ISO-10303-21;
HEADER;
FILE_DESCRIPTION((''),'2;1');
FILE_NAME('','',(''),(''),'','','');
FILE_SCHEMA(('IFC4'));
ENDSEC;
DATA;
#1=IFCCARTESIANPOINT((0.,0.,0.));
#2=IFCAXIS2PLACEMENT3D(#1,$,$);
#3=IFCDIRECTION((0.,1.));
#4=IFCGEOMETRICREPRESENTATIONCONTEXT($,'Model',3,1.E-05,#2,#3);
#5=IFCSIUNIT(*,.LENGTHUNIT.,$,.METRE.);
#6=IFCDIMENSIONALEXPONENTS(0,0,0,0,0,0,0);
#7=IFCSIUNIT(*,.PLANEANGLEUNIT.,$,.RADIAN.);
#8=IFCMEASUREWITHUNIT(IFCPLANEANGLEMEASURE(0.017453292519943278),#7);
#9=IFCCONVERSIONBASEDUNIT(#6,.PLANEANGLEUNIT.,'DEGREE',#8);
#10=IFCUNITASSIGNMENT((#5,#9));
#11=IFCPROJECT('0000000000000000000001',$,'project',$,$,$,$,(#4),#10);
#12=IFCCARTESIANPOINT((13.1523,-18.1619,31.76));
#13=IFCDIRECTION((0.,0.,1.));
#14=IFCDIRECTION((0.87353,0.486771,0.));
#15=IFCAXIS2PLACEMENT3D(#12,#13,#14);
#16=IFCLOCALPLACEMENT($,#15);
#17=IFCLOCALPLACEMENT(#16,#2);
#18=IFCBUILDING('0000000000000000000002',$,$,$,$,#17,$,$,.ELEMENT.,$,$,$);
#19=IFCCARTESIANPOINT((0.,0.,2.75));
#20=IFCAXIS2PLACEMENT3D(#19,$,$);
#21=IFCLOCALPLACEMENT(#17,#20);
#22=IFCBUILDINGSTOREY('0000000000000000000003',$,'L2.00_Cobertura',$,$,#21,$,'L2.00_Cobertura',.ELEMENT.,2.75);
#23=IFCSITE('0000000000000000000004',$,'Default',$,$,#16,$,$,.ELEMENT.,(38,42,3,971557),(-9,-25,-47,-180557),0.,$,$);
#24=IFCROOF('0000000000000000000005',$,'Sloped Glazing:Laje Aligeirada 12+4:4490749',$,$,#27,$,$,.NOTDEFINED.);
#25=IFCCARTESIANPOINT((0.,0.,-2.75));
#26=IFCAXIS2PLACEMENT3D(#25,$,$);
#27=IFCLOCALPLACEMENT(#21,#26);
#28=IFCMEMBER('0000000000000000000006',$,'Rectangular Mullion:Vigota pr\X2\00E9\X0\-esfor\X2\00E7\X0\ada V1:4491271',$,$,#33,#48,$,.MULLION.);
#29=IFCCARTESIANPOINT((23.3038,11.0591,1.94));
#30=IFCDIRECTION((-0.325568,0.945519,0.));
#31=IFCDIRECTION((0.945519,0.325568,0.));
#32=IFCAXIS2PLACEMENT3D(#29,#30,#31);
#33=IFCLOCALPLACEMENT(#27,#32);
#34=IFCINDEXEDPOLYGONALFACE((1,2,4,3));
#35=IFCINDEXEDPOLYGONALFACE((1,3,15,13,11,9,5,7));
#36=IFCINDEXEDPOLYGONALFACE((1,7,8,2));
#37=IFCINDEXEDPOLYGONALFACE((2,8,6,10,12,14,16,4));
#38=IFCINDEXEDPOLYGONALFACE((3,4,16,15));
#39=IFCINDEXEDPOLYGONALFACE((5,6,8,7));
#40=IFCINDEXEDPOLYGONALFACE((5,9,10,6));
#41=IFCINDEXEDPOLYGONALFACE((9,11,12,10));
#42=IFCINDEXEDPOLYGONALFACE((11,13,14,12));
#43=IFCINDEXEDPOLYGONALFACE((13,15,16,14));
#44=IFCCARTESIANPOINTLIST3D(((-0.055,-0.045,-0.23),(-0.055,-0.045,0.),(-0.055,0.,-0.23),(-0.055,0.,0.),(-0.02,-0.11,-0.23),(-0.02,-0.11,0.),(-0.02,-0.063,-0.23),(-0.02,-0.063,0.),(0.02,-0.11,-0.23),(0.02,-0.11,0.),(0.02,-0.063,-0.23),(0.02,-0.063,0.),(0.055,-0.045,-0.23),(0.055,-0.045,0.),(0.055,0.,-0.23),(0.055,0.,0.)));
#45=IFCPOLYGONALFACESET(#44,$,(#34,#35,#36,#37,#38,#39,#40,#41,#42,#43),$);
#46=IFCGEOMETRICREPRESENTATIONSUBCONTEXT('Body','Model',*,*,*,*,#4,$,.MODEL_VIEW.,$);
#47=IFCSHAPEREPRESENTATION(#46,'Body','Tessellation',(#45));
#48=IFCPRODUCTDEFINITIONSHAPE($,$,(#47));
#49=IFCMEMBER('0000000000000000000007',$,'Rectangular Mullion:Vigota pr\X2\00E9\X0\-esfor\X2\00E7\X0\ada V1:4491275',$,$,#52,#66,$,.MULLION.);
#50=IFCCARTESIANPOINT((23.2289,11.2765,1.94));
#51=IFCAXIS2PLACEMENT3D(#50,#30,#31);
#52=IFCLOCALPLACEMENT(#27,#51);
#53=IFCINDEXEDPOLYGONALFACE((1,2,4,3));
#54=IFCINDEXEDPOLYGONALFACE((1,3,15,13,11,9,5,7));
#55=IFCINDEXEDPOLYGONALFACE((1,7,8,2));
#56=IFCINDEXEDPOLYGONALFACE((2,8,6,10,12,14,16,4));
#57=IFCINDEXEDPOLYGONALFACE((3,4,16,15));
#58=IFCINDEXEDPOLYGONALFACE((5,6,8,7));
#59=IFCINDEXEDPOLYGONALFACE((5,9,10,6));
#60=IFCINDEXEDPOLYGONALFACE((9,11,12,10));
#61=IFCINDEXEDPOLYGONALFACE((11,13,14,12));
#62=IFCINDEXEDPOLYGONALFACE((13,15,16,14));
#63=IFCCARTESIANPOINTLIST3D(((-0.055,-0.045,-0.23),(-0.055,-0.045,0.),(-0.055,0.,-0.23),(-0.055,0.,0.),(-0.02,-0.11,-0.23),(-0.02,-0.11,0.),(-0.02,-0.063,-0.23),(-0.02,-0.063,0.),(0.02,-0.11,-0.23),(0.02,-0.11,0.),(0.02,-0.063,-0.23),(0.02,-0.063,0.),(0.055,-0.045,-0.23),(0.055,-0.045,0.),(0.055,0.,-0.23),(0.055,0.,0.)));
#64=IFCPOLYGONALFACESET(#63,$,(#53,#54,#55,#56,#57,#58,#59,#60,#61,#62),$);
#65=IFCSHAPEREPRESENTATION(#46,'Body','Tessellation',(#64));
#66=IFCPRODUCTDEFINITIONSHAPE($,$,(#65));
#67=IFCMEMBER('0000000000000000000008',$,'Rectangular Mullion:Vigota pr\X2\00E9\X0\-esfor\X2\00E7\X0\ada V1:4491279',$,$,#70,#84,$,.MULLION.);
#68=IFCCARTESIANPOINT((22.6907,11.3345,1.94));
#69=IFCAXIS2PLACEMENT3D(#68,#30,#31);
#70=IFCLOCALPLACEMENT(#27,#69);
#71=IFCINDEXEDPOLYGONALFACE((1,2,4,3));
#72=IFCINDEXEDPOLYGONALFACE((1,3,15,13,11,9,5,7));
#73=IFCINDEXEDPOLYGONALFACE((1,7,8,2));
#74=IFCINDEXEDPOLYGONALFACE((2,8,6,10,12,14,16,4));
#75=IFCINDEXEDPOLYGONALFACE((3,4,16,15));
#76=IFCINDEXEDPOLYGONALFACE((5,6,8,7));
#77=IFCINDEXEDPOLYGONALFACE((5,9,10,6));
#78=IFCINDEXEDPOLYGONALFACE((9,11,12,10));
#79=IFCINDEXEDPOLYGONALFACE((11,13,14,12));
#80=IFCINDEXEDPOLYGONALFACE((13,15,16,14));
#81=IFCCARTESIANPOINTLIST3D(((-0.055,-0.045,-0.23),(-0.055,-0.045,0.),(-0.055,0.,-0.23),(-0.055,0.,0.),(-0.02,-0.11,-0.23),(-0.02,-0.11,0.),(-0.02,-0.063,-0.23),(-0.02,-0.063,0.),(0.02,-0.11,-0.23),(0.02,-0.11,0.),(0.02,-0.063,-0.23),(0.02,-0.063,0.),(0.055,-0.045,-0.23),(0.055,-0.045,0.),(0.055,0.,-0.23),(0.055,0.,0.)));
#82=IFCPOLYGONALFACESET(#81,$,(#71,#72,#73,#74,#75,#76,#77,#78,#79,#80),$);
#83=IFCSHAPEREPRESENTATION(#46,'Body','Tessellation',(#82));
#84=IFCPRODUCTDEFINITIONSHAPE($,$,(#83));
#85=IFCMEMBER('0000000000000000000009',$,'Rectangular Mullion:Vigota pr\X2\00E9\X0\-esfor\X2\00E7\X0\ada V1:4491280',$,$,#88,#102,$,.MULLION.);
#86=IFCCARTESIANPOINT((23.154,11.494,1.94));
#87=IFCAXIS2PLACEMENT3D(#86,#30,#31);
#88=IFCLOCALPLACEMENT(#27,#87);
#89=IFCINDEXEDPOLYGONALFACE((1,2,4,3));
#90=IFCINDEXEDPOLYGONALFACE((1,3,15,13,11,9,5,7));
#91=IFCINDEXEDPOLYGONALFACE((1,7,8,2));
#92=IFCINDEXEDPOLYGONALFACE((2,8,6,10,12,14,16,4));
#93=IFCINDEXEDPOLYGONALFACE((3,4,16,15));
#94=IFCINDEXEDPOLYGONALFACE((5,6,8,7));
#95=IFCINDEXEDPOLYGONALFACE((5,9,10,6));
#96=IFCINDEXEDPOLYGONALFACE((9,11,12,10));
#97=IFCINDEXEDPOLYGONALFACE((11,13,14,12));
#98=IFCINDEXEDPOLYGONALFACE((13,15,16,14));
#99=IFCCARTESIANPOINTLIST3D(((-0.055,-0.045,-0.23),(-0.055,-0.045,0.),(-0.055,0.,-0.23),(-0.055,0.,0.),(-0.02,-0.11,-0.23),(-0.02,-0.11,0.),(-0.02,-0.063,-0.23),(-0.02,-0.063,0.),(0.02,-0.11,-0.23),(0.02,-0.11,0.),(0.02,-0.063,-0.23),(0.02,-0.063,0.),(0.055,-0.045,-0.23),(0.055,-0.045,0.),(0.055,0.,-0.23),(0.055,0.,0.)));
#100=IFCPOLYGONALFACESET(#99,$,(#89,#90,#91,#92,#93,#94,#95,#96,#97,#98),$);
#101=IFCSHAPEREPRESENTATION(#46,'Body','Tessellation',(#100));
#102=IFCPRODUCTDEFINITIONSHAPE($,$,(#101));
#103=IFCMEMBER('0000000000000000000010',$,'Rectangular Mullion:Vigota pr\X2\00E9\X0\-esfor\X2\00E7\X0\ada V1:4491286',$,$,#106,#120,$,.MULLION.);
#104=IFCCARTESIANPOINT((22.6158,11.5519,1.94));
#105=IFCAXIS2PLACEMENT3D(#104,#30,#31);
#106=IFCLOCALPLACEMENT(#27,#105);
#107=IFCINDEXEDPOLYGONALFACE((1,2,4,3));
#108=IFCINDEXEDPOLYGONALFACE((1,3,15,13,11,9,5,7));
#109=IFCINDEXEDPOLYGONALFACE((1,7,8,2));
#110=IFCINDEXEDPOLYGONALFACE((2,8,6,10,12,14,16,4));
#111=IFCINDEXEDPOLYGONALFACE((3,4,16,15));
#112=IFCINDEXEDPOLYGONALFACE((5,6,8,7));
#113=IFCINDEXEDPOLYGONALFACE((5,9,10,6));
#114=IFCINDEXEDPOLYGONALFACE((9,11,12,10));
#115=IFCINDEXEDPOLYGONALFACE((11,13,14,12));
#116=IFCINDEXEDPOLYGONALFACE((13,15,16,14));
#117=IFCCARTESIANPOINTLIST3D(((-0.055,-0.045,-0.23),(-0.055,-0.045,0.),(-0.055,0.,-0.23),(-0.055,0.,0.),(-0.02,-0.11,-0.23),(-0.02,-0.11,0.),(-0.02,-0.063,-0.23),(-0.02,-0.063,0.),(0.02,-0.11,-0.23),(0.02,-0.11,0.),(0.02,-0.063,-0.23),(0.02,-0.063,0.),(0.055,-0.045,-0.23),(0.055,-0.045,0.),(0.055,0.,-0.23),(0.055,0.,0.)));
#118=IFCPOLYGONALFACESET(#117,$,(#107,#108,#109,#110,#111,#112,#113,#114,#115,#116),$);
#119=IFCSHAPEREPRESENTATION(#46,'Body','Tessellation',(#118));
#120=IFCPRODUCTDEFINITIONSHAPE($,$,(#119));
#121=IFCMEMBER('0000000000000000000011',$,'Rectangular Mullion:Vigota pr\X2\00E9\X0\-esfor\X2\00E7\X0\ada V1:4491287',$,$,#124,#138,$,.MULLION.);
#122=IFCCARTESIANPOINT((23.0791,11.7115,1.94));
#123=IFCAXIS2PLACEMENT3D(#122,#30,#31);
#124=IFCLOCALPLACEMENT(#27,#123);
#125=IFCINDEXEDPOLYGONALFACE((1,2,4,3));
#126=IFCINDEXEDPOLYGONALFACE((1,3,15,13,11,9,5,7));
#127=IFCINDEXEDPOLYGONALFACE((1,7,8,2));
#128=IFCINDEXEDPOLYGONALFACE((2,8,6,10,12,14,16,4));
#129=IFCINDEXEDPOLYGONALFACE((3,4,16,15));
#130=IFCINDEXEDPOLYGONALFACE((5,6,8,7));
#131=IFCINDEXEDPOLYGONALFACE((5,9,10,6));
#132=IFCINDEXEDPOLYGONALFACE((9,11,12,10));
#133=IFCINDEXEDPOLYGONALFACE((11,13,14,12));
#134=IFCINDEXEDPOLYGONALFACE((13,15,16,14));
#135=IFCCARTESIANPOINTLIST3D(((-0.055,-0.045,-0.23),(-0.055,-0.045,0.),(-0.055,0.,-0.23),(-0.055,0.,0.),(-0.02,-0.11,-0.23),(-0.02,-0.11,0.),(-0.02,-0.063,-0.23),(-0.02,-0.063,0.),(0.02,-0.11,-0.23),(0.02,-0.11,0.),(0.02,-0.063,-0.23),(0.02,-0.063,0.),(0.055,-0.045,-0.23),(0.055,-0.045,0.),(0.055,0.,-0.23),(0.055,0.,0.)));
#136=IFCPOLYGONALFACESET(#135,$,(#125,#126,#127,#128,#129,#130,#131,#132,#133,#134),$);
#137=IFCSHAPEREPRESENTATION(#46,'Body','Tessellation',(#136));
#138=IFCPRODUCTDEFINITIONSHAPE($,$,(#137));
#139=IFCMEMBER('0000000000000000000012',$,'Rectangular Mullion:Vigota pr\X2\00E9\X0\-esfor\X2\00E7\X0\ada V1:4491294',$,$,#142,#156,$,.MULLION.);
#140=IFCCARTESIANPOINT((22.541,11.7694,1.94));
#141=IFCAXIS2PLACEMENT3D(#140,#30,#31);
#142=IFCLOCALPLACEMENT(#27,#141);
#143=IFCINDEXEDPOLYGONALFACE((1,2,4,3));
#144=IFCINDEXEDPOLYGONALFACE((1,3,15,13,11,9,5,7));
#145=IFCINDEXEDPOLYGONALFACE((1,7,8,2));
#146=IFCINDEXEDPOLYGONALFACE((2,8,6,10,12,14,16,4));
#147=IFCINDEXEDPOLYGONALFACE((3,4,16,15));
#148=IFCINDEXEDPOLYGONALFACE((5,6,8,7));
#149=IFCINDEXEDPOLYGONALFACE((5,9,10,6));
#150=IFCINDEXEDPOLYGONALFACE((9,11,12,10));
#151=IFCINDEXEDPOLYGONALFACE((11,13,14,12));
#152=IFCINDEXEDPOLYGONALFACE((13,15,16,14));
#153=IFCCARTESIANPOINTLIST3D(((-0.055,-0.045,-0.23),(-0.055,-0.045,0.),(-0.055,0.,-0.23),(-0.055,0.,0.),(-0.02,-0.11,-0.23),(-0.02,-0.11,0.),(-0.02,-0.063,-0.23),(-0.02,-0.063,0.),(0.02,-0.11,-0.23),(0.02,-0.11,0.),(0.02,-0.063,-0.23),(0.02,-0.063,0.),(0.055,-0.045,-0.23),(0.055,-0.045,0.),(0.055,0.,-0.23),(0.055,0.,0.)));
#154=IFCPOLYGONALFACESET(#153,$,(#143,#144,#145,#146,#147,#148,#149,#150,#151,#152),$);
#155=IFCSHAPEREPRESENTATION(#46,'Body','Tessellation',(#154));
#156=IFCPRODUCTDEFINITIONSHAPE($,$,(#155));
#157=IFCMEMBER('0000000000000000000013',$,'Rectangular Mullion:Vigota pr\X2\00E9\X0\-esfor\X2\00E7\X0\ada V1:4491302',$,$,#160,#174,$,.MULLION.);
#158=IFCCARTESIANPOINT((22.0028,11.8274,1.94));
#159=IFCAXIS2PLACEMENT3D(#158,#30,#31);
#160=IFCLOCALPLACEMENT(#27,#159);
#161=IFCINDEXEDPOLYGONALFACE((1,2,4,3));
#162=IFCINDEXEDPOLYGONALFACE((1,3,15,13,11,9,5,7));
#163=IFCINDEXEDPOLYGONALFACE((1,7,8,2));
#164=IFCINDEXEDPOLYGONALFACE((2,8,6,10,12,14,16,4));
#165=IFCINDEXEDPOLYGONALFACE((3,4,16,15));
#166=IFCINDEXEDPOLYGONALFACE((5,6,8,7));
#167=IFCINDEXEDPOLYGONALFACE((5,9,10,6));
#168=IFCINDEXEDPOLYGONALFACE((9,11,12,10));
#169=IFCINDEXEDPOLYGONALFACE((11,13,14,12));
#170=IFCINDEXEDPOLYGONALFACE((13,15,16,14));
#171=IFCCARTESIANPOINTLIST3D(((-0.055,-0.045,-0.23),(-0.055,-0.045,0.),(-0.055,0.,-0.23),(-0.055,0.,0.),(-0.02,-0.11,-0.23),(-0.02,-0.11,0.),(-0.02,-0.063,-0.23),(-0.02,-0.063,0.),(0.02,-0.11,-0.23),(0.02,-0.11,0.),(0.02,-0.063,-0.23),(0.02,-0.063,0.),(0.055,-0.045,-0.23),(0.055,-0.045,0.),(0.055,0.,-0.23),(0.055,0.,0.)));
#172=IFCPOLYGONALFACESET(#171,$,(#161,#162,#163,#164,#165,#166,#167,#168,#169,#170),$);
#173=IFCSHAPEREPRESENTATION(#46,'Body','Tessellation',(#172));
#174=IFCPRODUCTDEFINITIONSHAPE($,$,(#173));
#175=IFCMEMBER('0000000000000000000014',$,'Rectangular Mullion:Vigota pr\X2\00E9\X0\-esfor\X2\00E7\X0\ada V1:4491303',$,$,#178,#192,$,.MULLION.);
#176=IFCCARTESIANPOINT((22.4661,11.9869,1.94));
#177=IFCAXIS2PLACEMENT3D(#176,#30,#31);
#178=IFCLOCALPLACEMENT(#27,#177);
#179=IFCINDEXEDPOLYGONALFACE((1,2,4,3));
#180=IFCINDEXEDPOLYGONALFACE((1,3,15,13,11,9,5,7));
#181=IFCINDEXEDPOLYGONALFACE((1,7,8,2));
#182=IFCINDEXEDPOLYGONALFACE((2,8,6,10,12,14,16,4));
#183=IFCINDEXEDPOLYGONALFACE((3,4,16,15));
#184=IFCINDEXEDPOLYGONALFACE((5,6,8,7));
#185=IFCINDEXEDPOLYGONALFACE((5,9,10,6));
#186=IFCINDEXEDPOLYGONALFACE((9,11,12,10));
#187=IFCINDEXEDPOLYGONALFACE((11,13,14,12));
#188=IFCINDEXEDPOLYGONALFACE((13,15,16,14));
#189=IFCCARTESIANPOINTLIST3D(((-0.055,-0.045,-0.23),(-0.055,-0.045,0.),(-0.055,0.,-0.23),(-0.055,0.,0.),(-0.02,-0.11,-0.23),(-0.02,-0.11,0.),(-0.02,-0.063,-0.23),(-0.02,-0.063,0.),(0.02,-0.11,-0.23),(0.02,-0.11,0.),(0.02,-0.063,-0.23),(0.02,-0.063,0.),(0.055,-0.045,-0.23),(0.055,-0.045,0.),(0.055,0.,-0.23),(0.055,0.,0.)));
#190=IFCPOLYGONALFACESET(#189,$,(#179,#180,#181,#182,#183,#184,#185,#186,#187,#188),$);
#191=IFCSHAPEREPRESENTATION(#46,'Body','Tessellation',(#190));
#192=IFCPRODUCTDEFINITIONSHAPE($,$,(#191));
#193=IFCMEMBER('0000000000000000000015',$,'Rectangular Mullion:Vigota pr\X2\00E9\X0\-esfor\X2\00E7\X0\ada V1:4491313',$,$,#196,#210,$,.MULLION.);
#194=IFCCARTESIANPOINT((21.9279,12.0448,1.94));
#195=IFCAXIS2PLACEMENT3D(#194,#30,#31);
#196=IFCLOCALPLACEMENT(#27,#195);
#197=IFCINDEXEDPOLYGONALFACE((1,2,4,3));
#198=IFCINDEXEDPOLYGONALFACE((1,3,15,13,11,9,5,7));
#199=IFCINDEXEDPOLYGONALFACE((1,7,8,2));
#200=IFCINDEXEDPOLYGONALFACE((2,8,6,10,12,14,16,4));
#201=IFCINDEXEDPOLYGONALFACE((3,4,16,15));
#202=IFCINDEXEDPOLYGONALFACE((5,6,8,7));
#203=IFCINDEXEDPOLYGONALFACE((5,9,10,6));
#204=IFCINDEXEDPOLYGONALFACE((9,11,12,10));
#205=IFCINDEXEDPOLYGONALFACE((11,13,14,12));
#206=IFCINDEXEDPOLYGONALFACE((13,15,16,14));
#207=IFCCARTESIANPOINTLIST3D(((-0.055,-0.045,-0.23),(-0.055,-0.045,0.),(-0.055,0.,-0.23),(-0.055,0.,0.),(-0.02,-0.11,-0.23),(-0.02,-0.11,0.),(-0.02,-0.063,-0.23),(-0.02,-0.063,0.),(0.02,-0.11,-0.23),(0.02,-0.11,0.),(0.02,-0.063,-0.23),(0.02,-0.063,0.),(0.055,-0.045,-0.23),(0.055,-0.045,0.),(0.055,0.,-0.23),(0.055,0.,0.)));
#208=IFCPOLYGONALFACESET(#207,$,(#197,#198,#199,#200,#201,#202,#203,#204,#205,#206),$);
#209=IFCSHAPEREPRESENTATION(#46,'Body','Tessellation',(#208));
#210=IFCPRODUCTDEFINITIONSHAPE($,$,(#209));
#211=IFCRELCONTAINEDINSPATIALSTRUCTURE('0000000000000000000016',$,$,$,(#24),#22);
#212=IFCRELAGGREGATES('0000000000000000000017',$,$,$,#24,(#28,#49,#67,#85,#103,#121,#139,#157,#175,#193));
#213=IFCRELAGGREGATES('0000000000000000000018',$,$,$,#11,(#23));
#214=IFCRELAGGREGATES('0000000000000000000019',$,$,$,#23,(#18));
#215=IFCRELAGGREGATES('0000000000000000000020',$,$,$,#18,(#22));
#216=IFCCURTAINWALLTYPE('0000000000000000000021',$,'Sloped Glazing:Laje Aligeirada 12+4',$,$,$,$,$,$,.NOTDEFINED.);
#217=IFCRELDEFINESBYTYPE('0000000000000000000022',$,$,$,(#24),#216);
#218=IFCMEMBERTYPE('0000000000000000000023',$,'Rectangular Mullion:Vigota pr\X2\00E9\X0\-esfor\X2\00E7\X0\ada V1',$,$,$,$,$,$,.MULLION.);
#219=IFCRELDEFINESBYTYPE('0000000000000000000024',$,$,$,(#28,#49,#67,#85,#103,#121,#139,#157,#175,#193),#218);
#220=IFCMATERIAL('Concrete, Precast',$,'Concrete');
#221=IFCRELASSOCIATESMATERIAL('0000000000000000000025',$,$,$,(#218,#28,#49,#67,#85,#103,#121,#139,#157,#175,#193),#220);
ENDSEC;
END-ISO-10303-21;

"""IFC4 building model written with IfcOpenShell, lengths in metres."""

from ifc_helpers import new_model, entity, si_unit, converted_unit, direction, frame, origin, place, context, subcontext, project, spatial, indexed_curve, outline, extrude, source, transform, mapped, material, type_object, type_shapes, element, aggregate, save


model = new_model("IFC4")

# Units and contexts
model_context = context("Model", 3, precision=1e-05, world=origin(), true_north=direction((0.0, 1.0)))
body_context = subcontext(model_context, "Body", "Model", "MODEL_VIEW")
ifc_project = project(units=[si_unit("LENGTHUNIT", "METRE"), converted_unit("PLANEANGLEUNIT", "DEGREE", entity("IfcPlaneAngleMeasure", 0.017453292519943278), si_unit("PLANEANGLEUNIT", "RADIAN"), dimensions=[0, 0, 0, 0, 0, 0, 0])], contexts=[model_context])

# Site, building, storey
site_placement = place(None, frame((13.1523, -18.1619, 31.76), z_axis=(0.0, 0.0, 1.0), x_axis=(0.87353, 0.486771, 0.0)))
site = spatial("IfcSite", under=ifc_project, at=site_placement, Name="Default", CompositionType="ELEMENT", RefLatitude=(38, 42, 3, 971557), RefLongitude=(-9, -25, -47, -180557), RefElevation=0.0)
building_placement = place(site_placement, origin())
building = spatial("IfcBuilding", under=site, at=building_placement, CompositionType="ELEMENT")
storey_placement = place(building_placement, frame((0.0, 0.0, 2.75)))
storey = spatial("IfcBuildingStorey", under=building, at=storey_placement, Name="L2.00_Cobertura", LongName="L2.00_Cobertura", CompositionType="ELEMENT", Elevation=2.75)

# Roof, members
curtain_wall_type = type_object("IfcCurtainWallType", Name="Sloped Glazing:Laje Aligeirada 12+4", PredefinedType="NOTDEFINED")
roof_placement = place(storey_placement, frame((0.0, 0.0, -2.75)))
roof = element("IfcRoof", 1, at=roof_placement, inside=storey, type_object=curtain_wall_type, Name="Sloped Glazing:Laje Aligeirada 12+4:4490749", PredefinedType="NOTDEFINED")
ifc_material_1 = material(Name="Concrete, Precast", Category="Concrete")
member_type_1 = type_object("IfcMemberType", Name="Rectangular Mullion:Vigota pré-esforçada V1", PredefinedType="MULLION", material=ifc_material_1)
shared_shape_1 = source(origin(), body_context, "Body", "SweptSolid", [
    extrude(outline(indexed_curve([(-0.055, -0.0545), (0.055, -0.0545), (0.055, -0.0095), (0.02, 0.0085), (0.02, 0.0555), (-0.02, 0.0555), (-0.02, 0.0085), (-0.055, -0.0095), (-0.055, -0.0545)], self_intersect=False)), frame((0.0, -0.0545, -0.23), z_axis=(0.0, 0.0, 1.0), x_axis=(-1.0, 0.0, 0.0)), (0.0, 0.0, 1.0), 0.23),
])
type_shapes(member_type_1, [shared_shape_1])
member_1_placement = place(roof_placement, frame((23.3038, 11.0591, 1.94), z_axis=(-0.325568, 0.945519, 0.0), x_axis=(0.945519, 0.325568, 0.0)))
member_1 = element("IfcMember", 2, at=member_1_placement, type_object=member_type_1, material=ifc_material_1, Name="Rectangular Mullion:Vigota pré-esforçada V1:4491271", PredefinedType="MULLION", context=body_context, shape_type="MappedRepresentation", body=[
    mapped(shared_shape_1, transform((0.0, 0.0, 0.0), scale=1.0)),
])
member_2_placement = place(roof_placement, frame((23.2289, 11.2765, 1.94), z_axis=(-0.325568, 0.945519, 0.0), x_axis=(0.945519, 0.325568, 0.0)))
member_2 = element("IfcMember", 3, at=member_2_placement, type_object=member_type_1, material=ifc_material_1, Name="Rectangular Mullion:Vigota pré-esforçada V1:4491275", PredefinedType="MULLION", context=body_context, shape_type="MappedRepresentation", body=[
    mapped(shared_shape_1, transform((0.0, 0.0, 0.0), scale=1.0)),
])
member_3_placement = place(roof_placement, frame((22.6907, 11.3345, 1.94), z_axis=(-0.325568, 0.945519, 0.0), x_axis=(0.945519, 0.325568, 0.0)))
member_3 = element("IfcMember", 4, at=member_3_placement, type_object=member_type_1, material=ifc_material_1, Name="Rectangular Mullion:Vigota pré-esforçada V1:4491279", PredefinedType="MULLION", context=body_context, shape_type="MappedRepresentation", body=[
    mapped(shared_shape_1, transform((0.0, 0.0, 0.0), scale=1.0)),
])
member_4_placement = place(roof_placement, frame((23.154, 11.494, 1.94), z_axis=(-0.325568, 0.945519, 0.0), x_axis=(0.945519, 0.325568, 0.0)))
member_4 = element("IfcMember", 5, at=member_4_placement, type_object=member_type_1, material=ifc_material_1, Name="Rectangular Mullion:Vigota pré-esforçada V1:4491280", PredefinedType="MULLION", context=body_context, shape_type="MappedRepresentation", body=[
    mapped(shared_shape_1, transform((0.0, 0.0, 0.0), scale=1.0)),
])
member_5_placement = place(roof_placement, frame((22.6158, 11.5519, 1.94), z_axis=(-0.325568, 0.945519, 0.0), x_axis=(0.945519, 0.325568, 0.0)))
member_5 = element("IfcMember", 6, at=member_5_placement, type_object=member_type_1, material=ifc_material_1, Name="Rectangular Mullion:Vigota pré-esforçada V1:4491286", PredefinedType="MULLION", context=body_context, shape_type="MappedRepresentation", body=[
    mapped(shared_shape_1, transform((0.0, 0.0, 0.0), scale=1.0)),
])
member_6_placement = place(roof_placement, frame((23.0791, 11.7115, 1.94), z_axis=(-0.325568, 0.945519, 0.0), x_axis=(0.945519, 0.325568, 0.0)))
member_6 = element("IfcMember", 7, at=member_6_placement, type_object=member_type_1, material=ifc_material_1, Name="Rectangular Mullion:Vigota pré-esforçada V1:4491287", PredefinedType="MULLION", context=body_context, shape_type="MappedRepresentation", body=[
    mapped(shared_shape_1, transform((0.0, 0.0, 0.0), scale=1.0)),
])
member_7_placement = place(roof_placement, frame((22.541, 11.7694, 1.94), z_axis=(-0.325568, 0.945519, 0.0), x_axis=(0.945519, 0.325568, 0.0)))
member_7 = element("IfcMember", 8, at=member_7_placement, type_object=member_type_1, material=ifc_material_1, Name="Rectangular Mullion:Vigota pré-esforçada V1:4491294", PredefinedType="MULLION", context=body_context, shape_type="MappedRepresentation", body=[
    mapped(shared_shape_1, transform((0.0, 0.0, 0.0), scale=1.0)),
])
member_8_placement = place(roof_placement, frame((22.0028, 11.8274, 1.94), z_axis=(-0.325568, 0.945519, 0.0), x_axis=(0.945519, 0.325568, 0.0)))
member_8 = element("IfcMember", 9, at=member_8_placement, type_object=member_type_1, material=ifc_material_1, Name="Rectangular Mullion:Vigota pré-esforçada V1:4491302", PredefinedType="MULLION", context=body_context, shape_type="MappedRepresentation", body=[
    mapped(shared_shape_1, transform((0.0, 0.0, 0.0), scale=1.0)),
])
member_9_placement = place(roof_placement, frame((22.4661, 11.9869, 1.94), z_axis=(-0.325568, 0.945519, 0.0), x_axis=(0.945519, 0.325568, 0.0)))
member_9 = element("IfcMember", 10, at=member_9_placement, type_object=member_type_1, material=ifc_material_1, Name="Rectangular Mullion:Vigota pré-esforçada V1:4491303", PredefinedType="MULLION", context=body_context, shape_type="MappedRepresentation", body=[
    mapped(shared_shape_1, transform((0.0, 0.0, 0.0), scale=1.0)),
])
member_10_placement = place(roof_placement, frame((21.9279, 12.0448, 1.94), z_axis=(-0.325568, 0.945519, 0.0), x_axis=(0.945519, 0.325568, 0.0)))
member_10 = element("IfcMember", 11, at=member_10_placement, type_object=member_type_1, material=ifc_material_1, Name="Rectangular Mullion:Vigota pré-esforçada V1:4491313", PredefinedType="MULLION", context=body_context, shape_type="MappedRepresentation", body=[
    mapped(shared_shape_1, transform((0.0, 0.0, 0.0), scale=1.0)),
])
aggregate(roof, [member_1, member_2, member_3, member_4, member_5, member_6, member_7, member_8, member_9, member_10])

save(model, "model.ifc")
